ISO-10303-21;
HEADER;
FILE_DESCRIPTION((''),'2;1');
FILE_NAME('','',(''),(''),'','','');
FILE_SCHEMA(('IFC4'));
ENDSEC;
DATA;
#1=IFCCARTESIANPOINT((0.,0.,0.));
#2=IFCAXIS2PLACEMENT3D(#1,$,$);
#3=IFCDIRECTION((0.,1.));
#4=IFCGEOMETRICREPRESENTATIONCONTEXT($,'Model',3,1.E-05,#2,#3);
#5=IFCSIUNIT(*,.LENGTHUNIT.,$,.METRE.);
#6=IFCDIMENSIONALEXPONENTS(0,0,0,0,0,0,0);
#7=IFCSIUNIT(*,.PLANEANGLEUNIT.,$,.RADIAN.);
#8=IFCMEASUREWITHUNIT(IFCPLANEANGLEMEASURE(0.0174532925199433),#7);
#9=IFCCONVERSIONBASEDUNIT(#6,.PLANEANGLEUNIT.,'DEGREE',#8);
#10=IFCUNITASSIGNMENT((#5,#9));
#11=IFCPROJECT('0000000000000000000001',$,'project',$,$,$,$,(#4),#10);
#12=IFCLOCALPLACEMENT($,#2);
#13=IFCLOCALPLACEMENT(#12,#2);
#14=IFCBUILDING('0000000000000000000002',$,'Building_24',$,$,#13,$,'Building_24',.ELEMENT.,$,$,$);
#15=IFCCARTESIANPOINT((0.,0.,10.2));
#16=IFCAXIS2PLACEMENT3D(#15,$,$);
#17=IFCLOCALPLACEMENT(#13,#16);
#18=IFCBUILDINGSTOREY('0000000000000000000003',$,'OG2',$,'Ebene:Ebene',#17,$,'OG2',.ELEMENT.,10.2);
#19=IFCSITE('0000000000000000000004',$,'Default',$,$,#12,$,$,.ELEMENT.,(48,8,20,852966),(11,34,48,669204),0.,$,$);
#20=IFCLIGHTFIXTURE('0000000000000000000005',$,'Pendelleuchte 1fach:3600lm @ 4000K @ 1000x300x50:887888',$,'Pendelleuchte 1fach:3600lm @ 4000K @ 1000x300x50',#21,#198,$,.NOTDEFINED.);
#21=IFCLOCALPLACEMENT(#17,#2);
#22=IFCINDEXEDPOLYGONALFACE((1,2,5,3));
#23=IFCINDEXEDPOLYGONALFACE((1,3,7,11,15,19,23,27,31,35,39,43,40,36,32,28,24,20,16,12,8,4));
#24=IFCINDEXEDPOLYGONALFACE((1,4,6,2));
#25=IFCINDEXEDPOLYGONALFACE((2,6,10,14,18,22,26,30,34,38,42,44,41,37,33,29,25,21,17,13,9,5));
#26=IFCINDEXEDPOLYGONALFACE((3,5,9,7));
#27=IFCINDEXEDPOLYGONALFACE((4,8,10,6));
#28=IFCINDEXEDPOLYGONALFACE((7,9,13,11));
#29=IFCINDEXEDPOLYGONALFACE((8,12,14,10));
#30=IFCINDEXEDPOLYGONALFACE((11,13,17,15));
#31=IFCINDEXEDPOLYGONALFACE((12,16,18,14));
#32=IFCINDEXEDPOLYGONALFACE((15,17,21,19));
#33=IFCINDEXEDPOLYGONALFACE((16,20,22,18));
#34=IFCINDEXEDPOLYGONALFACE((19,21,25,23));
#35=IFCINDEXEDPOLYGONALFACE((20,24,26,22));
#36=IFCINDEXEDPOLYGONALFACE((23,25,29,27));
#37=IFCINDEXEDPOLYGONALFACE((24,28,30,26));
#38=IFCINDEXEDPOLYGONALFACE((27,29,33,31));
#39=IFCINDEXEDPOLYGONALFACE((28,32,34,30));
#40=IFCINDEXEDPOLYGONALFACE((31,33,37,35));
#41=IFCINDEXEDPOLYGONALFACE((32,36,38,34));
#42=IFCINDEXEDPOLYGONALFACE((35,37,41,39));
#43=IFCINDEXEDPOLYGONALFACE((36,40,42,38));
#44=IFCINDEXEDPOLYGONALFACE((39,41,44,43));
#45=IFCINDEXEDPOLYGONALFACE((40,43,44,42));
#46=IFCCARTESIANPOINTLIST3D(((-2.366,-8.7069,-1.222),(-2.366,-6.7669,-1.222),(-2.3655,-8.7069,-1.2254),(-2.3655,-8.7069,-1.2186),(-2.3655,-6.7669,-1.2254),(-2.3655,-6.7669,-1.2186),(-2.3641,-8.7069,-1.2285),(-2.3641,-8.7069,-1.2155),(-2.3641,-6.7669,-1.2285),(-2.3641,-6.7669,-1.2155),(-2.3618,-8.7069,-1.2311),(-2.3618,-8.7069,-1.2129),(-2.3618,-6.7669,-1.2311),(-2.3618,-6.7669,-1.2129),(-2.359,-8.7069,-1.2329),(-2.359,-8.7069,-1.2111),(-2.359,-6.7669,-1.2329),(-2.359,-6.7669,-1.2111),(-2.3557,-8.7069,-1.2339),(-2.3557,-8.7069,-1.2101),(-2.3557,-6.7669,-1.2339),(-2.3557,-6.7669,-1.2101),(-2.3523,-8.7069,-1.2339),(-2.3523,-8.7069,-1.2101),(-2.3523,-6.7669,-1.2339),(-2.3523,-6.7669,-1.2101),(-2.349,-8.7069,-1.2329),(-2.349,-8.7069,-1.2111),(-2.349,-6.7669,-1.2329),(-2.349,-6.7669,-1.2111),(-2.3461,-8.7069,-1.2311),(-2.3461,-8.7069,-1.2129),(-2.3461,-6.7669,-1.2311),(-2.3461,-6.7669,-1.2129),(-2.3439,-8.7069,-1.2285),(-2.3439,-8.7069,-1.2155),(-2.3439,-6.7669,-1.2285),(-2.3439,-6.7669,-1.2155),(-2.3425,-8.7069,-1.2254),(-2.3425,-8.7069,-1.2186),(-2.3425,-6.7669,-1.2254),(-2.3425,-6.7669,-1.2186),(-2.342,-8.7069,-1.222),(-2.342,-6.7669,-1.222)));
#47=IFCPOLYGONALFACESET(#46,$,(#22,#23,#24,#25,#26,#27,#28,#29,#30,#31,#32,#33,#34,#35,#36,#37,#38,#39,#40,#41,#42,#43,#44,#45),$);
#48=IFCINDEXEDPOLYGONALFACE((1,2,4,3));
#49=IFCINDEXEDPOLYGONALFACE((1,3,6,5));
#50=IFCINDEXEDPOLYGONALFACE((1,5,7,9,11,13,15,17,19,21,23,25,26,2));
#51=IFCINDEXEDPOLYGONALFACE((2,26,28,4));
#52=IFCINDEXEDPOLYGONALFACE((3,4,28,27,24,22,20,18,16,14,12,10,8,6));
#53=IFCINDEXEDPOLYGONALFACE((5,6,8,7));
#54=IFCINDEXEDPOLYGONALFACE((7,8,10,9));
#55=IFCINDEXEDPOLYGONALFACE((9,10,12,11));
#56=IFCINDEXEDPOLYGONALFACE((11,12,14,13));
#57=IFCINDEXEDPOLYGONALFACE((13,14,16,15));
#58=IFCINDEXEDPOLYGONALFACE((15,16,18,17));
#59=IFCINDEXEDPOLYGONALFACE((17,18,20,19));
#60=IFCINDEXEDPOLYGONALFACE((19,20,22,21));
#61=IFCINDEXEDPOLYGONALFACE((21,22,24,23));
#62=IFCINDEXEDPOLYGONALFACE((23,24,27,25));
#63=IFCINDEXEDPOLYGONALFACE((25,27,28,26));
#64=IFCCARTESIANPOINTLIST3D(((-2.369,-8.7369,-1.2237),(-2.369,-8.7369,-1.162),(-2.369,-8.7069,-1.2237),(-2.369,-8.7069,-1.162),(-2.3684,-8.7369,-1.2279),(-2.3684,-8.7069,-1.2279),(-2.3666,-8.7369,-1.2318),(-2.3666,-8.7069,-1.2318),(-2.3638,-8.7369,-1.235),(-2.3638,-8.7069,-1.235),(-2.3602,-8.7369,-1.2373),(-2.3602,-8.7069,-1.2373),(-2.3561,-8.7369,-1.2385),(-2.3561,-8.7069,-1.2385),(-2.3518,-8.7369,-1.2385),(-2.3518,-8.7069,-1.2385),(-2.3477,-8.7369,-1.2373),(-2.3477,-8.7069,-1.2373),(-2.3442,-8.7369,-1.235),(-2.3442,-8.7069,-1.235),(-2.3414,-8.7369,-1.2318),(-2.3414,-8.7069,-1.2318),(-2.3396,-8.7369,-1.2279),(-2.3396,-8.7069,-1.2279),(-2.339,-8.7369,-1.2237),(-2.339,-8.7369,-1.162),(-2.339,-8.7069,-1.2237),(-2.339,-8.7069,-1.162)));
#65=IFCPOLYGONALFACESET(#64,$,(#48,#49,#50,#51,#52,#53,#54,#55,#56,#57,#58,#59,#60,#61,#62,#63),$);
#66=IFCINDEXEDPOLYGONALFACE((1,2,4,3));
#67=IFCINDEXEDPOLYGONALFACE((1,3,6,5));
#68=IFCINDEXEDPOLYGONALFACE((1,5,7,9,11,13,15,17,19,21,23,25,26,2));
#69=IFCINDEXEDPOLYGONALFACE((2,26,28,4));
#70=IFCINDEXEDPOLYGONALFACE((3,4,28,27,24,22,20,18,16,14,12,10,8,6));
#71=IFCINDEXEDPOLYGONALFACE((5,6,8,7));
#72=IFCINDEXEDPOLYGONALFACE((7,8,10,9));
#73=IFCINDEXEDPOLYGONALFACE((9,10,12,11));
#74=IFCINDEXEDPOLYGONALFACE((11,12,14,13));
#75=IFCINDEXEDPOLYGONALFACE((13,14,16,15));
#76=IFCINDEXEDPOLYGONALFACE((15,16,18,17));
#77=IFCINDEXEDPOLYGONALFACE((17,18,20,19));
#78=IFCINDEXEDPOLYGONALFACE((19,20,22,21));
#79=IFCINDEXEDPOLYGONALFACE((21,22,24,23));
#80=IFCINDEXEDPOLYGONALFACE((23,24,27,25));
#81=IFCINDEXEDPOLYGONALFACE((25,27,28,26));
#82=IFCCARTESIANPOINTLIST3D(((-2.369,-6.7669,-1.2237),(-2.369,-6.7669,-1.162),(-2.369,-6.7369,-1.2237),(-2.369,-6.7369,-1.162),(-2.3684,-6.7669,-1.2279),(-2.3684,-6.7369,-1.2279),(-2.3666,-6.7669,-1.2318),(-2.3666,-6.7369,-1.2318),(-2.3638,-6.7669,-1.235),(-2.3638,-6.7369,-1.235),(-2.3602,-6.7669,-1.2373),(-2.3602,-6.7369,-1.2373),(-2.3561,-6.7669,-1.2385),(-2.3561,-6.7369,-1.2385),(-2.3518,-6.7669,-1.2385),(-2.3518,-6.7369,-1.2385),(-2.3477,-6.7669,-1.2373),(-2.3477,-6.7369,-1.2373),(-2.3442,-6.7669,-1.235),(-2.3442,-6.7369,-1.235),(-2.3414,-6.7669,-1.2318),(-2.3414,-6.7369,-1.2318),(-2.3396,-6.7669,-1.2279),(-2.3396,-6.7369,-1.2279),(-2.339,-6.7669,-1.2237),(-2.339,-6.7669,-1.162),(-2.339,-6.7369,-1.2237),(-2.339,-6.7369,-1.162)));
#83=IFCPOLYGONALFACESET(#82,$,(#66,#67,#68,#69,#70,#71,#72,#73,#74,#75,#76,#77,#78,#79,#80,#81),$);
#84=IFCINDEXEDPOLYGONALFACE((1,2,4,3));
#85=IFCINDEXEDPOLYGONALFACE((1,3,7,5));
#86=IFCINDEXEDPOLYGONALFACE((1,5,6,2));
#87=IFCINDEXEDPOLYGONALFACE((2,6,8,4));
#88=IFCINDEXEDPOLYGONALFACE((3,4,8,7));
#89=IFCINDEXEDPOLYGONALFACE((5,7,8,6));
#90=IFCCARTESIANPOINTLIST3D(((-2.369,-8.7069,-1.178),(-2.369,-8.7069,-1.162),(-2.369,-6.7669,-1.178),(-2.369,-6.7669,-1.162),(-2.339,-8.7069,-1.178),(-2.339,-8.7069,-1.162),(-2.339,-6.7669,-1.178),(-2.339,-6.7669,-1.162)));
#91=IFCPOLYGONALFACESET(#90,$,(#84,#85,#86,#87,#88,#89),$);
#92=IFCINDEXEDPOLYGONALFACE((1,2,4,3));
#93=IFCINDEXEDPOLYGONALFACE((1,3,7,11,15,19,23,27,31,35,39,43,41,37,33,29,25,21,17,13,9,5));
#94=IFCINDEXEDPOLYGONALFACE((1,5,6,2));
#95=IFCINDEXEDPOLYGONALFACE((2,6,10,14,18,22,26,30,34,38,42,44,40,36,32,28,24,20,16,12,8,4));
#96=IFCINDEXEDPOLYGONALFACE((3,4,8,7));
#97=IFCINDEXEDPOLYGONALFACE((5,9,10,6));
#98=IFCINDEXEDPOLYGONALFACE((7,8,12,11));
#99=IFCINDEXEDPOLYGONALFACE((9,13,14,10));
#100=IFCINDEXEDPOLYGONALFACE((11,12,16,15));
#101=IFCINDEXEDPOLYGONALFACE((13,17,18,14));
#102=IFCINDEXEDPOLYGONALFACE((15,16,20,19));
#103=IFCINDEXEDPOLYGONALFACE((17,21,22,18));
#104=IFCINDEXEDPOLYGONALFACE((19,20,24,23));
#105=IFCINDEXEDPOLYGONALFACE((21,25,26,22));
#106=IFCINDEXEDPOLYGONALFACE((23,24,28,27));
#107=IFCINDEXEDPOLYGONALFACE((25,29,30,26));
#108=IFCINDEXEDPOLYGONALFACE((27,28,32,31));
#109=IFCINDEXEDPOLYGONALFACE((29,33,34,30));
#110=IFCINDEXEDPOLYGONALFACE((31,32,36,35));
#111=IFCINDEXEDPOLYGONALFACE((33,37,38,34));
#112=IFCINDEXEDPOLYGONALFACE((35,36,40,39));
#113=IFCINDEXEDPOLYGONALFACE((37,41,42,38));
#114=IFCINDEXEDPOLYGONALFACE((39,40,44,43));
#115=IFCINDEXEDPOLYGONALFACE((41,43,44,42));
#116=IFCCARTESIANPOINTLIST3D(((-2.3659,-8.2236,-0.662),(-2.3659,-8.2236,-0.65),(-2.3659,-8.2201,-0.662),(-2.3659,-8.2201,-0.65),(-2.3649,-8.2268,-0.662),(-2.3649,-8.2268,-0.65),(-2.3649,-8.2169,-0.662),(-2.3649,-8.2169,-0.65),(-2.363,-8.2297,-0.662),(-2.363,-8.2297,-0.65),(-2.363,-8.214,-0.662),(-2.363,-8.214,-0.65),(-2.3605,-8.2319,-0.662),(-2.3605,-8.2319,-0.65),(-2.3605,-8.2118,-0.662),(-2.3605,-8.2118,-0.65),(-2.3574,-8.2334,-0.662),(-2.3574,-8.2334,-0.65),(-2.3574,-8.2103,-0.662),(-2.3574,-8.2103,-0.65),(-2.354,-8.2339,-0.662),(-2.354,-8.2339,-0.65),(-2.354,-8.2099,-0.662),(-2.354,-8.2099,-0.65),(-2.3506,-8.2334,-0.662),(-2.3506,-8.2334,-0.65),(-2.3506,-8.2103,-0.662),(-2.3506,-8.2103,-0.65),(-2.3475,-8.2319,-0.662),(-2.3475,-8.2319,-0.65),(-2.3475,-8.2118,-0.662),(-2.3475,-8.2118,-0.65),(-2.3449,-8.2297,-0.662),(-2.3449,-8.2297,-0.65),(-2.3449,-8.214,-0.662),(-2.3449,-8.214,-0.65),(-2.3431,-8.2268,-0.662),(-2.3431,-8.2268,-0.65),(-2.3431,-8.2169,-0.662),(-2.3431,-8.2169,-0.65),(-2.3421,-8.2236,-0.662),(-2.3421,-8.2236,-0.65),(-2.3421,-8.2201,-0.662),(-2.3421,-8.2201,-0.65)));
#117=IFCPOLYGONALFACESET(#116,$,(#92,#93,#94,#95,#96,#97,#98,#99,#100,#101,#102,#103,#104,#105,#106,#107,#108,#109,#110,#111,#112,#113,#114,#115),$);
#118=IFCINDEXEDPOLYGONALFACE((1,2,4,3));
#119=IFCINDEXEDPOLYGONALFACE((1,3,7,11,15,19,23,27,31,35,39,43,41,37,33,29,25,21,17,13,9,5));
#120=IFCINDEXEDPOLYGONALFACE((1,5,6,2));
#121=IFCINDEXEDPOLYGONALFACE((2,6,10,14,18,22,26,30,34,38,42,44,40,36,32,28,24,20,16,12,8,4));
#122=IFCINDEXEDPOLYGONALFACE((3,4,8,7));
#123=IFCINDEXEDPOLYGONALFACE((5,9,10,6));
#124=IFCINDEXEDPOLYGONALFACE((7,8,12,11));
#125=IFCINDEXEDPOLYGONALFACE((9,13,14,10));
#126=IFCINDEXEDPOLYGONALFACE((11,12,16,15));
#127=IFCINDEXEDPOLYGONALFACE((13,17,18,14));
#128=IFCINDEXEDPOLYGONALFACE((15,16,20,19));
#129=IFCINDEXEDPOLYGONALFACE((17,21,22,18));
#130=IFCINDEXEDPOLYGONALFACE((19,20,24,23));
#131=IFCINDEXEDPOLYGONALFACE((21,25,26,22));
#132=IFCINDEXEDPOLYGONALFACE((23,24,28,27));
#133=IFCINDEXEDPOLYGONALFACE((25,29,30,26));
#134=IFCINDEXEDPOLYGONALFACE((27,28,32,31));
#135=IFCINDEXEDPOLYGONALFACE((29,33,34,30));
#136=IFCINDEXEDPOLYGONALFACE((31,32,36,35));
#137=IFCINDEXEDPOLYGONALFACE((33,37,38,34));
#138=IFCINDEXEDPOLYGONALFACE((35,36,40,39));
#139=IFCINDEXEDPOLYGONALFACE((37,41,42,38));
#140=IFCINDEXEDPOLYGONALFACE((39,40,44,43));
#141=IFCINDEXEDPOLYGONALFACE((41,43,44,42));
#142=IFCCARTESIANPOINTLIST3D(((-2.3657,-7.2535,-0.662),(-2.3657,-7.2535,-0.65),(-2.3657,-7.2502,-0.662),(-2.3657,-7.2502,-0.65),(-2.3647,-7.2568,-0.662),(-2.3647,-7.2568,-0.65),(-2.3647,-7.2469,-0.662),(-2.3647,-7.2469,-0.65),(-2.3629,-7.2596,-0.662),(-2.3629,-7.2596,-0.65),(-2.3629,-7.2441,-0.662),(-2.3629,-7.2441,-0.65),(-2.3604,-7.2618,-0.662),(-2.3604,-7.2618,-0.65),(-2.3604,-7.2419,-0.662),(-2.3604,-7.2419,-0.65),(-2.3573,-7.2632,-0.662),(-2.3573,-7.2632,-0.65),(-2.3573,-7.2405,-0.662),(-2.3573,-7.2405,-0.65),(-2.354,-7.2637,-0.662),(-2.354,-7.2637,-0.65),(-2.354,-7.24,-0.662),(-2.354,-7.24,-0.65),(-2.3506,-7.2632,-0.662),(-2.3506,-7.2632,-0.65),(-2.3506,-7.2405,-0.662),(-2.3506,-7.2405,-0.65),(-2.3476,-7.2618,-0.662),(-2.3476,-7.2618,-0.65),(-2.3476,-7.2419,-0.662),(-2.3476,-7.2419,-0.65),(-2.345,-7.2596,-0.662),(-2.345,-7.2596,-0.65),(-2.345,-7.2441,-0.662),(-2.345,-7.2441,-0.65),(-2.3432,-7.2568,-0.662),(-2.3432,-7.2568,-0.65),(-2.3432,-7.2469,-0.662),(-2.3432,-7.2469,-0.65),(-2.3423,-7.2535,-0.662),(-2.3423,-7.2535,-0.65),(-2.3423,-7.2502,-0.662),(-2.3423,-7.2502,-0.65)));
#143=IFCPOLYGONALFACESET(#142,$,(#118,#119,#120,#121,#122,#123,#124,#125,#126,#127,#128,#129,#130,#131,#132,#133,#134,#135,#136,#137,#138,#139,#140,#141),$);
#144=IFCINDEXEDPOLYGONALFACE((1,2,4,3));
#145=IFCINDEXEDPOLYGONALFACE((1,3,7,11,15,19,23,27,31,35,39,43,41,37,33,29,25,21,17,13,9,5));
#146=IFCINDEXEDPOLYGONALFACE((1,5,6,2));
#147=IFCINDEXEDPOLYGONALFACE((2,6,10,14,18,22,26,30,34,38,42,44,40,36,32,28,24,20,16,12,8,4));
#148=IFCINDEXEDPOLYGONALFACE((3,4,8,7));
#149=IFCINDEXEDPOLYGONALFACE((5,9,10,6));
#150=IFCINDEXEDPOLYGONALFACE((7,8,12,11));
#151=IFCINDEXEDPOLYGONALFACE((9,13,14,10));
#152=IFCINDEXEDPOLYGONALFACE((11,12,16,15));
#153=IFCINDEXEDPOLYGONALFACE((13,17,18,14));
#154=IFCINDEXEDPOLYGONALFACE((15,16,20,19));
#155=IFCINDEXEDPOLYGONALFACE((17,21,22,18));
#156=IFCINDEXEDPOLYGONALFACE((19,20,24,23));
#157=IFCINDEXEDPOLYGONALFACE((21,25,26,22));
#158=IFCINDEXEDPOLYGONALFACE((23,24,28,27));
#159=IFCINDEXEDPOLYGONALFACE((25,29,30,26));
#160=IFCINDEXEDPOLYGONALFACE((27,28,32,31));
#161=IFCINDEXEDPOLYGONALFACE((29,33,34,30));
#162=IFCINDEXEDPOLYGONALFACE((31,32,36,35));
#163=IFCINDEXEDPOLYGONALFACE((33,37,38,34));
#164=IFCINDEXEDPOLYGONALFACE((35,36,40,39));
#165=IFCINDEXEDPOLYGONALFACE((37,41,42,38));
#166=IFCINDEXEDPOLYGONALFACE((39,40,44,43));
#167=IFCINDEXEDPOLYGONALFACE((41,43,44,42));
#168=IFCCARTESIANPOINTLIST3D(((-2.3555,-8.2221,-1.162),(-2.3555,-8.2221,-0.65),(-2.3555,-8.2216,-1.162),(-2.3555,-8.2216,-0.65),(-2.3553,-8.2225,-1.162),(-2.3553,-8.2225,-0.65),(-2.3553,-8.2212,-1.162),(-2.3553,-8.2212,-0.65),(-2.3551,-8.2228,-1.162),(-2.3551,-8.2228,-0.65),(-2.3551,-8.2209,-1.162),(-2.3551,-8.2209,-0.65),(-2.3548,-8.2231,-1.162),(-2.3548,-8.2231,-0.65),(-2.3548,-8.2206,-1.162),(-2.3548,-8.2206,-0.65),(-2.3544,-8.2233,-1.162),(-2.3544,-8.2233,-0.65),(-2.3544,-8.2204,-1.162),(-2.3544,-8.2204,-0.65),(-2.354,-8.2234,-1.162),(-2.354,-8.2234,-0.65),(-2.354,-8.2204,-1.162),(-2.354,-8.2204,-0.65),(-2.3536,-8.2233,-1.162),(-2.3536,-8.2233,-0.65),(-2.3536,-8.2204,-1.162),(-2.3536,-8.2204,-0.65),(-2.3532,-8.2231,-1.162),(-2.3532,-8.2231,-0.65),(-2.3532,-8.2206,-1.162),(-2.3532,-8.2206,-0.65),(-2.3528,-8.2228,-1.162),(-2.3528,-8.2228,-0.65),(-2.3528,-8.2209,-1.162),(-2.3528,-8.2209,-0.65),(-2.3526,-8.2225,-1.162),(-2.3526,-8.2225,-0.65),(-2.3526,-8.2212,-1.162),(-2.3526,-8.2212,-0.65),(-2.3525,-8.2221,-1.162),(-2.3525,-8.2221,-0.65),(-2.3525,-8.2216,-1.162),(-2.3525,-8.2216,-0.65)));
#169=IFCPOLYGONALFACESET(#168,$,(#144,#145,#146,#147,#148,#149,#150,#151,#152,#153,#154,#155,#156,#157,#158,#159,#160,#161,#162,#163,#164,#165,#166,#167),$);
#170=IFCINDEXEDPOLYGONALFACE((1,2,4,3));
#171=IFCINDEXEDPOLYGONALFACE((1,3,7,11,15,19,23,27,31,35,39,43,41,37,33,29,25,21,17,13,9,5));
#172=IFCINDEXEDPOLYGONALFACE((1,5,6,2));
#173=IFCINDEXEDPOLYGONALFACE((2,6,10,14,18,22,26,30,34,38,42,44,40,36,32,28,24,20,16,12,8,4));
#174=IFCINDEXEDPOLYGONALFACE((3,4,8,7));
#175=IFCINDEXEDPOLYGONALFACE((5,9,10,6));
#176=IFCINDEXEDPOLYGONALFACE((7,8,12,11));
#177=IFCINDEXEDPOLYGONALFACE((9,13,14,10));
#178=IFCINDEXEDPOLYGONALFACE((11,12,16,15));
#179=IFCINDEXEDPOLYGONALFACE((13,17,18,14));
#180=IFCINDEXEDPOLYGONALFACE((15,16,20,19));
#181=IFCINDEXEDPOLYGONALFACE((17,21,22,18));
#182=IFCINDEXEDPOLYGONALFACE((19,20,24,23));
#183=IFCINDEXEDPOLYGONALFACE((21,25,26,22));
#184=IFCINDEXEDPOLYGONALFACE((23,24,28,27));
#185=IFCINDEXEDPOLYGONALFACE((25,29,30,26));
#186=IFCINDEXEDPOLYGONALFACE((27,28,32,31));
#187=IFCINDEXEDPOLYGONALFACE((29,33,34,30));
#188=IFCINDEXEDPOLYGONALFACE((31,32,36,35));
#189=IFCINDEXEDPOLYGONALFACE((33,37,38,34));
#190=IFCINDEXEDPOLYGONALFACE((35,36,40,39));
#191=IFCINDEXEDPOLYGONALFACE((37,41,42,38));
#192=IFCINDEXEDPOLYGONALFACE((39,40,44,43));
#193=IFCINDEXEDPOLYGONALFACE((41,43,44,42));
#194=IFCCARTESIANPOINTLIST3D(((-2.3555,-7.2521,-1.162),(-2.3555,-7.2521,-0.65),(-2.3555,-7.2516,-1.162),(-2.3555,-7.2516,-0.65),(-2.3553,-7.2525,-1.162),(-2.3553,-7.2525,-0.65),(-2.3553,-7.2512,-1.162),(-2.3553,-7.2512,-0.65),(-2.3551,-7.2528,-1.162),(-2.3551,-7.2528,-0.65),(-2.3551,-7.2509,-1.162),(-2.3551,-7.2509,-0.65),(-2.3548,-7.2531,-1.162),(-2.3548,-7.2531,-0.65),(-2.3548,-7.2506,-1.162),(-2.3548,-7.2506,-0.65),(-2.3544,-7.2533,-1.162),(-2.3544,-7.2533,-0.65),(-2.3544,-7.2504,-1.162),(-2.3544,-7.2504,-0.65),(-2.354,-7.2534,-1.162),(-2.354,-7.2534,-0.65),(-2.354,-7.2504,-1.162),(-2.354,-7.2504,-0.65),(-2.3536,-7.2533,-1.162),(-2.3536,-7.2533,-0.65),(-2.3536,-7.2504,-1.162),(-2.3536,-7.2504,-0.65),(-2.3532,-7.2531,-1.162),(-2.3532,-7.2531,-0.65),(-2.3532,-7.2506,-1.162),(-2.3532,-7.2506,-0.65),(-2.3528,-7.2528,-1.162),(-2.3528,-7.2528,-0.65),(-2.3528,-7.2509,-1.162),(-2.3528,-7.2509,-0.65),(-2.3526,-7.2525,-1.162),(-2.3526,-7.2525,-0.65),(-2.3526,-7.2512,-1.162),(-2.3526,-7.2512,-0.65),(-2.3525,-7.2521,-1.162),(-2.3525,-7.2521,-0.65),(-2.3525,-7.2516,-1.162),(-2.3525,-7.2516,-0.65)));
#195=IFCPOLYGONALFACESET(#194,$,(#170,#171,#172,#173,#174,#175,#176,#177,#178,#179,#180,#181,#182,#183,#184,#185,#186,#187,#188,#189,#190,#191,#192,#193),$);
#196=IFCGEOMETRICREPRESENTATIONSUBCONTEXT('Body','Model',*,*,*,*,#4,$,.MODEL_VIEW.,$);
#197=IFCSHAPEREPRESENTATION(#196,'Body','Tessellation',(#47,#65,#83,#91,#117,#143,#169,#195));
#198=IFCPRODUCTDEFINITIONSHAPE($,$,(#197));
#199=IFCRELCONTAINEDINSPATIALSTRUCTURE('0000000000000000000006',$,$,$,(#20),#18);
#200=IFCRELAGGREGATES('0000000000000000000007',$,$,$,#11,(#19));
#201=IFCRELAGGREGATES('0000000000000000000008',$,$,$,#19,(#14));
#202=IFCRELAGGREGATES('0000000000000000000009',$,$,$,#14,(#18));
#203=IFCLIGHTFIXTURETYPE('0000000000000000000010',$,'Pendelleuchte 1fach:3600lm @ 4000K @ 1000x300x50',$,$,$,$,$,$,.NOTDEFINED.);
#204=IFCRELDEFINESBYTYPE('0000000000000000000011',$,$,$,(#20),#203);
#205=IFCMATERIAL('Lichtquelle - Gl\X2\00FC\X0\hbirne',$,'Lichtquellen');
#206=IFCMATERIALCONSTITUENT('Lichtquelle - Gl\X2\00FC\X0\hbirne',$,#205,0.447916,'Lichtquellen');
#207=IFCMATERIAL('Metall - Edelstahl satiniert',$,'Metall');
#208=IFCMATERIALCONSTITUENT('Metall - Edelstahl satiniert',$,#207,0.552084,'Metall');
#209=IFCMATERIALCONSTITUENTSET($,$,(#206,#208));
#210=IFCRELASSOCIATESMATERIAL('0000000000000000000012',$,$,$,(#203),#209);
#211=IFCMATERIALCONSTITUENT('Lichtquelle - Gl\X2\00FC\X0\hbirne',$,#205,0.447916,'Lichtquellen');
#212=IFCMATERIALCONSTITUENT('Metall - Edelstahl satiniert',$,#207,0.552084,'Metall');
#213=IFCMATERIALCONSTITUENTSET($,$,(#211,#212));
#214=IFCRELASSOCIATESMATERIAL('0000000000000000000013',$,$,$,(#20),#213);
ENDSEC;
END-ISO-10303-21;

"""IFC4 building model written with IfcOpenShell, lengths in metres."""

from ifc_helpers import new_model, entity, si_unit, converted_unit, direction, frame, origin, place, context, subcontext, project, spatial, line, arc, indexed_curve, outline, extrude, source, transform, mapped, material, constituent, constituent_set, type_object, type_shapes, element, save


model = new_model("IFC4")

# Units and contexts
model_context = context("Model", 3, precision=1e-05, world=origin(), true_north=direction((0.0, 1.0)))
body_context = subcontext(model_context, "Body", "Model", "MODEL_VIEW")
ifc_project = project(units=[si_unit("LENGTHUNIT", "METRE"), converted_unit("PLANEANGLEUNIT", "DEGREE", entity("IfcPlaneAngleMeasure", 0.0174532925199433), si_unit("PLANEANGLEUNIT", "RADIAN"), dimensions=[0, 0, 0, 0, 0, 0, 0])], contexts=[model_context])

# Site, building, storey
site_placement = place(None, origin())
site = spatial("IfcSite", under=ifc_project, at=site_placement, Name="Default", CompositionType="ELEMENT", RefLatitude=(48, 8, 20, 852966), RefLongitude=(11, 34, 48, 669204), RefElevation=0.0)
building_placement = place(site_placement, origin())
building = spatial("IfcBuilding", under=site, at=building_placement, Name="Building_24", LongName="Building_24", CompositionType="ELEMENT")
storey_placement = place(building_placement, frame((0.0, 0.0, 10.2)))
storey = spatial("IfcBuildingStorey", under=building, at=storey_placement, Name="OG2", ObjectType="Ebene:Ebene", LongName="OG2", CompositionType="ELEMENT", Elevation=10.2)

# Light fixture
ifc_material_1 = material(Name="Lichtquelle - Glühbirne", Category="Lichtquellen")
ifc_material_2 = material(Name="Metall - Edelstahl satiniert", Category="Metall")
ifc_constituent_1 = constituent(ifc_material_1, Name="Lichtquelle - Glühbirne", Category="Lichtquellen", fraction=0.447916)
ifc_constituent_2 = constituent(ifc_material_2, Name="Metall - Edelstahl satiniert", Category="Metall", fraction=0.552084)
ifc_constituent_set_1 = constituent_set(constituents=[ifc_constituent_1, ifc_constituent_2])
light_fixture_type_1 = type_object("IfcLightFixtureType", Name="Pendelleuchte 1fach:3600lm @ 4000K @ 1000x300x50", PredefinedType="NOTDEFINED", material=ifc_constituent_set_1)
shared_shape_1 = source(origin(), body_context, "Body", "SweptSolid", [
    extrude(outline(indexed_curve([(-0.012, 0.0), (0.0, -0.012), (0.012, 0.0), (0.0, 0.012)], segments=[arc(1, 2, 3), arc(3, 4, 1)], self_intersect=False)), frame((-0.97, 0.0, -0.572), z_axis=(1.0, 0.0, 0.0), x_axis=(0.0, 1.0, 0.0)), (0.0, 0.0, 1.0), 1.94),
    extrude(outline(indexed_curve([(-0.0308, -0.015), (0.0308, -0.015), (0.0308, 0.015), (-0.0308, 0.015), (-0.0458, 0.0)], segments=[line(1, 2, 3, 4), arc(4, 5, 1)], self_intersect=False)), frame((0.97, 0.0, -0.5428), z_axis=(1.0, 0.0, 0.0), x_axis=(0.0, 0.0, 1.0)), (0.0, 0.0, 1.0), 0.03),
    extrude(outline(indexed_curve([(-0.0308, -0.015), (0.0308, -0.015), (0.0308, 0.015), (-0.0308, 0.015), (-0.0458, 0.0)], segments=[line(1, 2, 3, 4), arc(4, 5, 1)], self_intersect=False)), frame((-1.0, 0.0, -0.5428), z_axis=(1.0, 0.0, 0.0), x_axis=(0.0, 0.0, 1.0)), (0.0, 0.0, 1.0), 0.03),
    extrude(outline(indexed_curve([(-0.97, -0.015), (0.97, -0.015), (0.97, 0.015), (-0.97, 0.015), (-0.97, -0.015)], self_intersect=False)), frame((0.0, 0.0, -0.528), z_axis=(0.0, 0.0, 1.0), x_axis=(-1.0, 0.0, 0.0)), (0.0, 0.0, 1.0), 0.016),
    extrude(outline(indexed_curve([(-0.012, 0.0), (0.0, -0.012), (0.012, 0.0), (0.0, 0.012)], segments=[arc(1, 2, 3), arc(3, 4, 1)], self_intersect=False)), frame((0.485, 0.0, -0.012)), (0.0, 0.0, 1.0), 0.012),
    extrude(outline(indexed_curve([(-0.0118, 0.0), (0.0, -0.0118), (0.0118, 0.0), (0.0, 0.0118)], segments=[arc(1, 2, 3), arc(3, 4, 1)], self_intersect=False)), frame((-0.485, 0.0, -0.012)), (0.0, 0.0, 1.0), 0.012),
    extrude(outline(indexed_curve([(-0.0015, 0.0), (0.0, -0.0015), (0.0015, 0.0), (0.0, 0.0015)], segments=[arc(1, 2, 3), arc(3, 4, 1)], self_intersect=False)), frame((0.485, 0.0, -0.512)), (0.0, 0.0, 1.0), 0.512),
    extrude(outline(indexed_curve([(-0.0015, 0.0), (0.0, -0.0015), (0.0015, 0.0), (0.0, 0.0015)], segments=[arc(1, 2, 3), arc(3, 4, 1)], self_intersect=False)), frame((-0.485, 0.0, -0.512)), (0.0, 0.0, 1.0), 0.512),
])
type_shapes(light_fixture_type_1, [shared_shape_1])
ifc_constituent_3 = constituent(ifc_material_1, Name="Lichtquelle - Glühbirne", Category="Lichtquellen", fraction=0.447916)
ifc_constituent_4 = constituent(ifc_material_2, Name="Metall - Edelstahl satiniert", Category="Metall", fraction=0.552084)
ifc_constituent_set_2 = constituent_set(constituents=[ifc_constituent_3, ifc_constituent_4])
light_fixture_1_placement = place(storey_placement, frame((-2.354, -7.7369, -0.65), z_axis=(0.0, 0.0, 1.0), x_axis=(0.0, -1.0, 0.0)))
element("IfcLightFixture", 1, at=light_fixture_1_placement, inside=storey, type_object=light_fixture_type_1, material=ifc_constituent_set_2, Name="Pendelleuchte 1fach:3600lm @ 4000K @ 1000x300x50:887888", ObjectType="Pendelleuchte 1fach:3600lm @ 4000K @ 1000x300x50", PredefinedType="NOTDEFINED", context=body_context, shape_type="MappedRepresentation", body=[
    mapped(shared_shape_1, transform((0.0, 0.0, 0.0), scale=1.0)),
])

save(model, "model.ifc")
